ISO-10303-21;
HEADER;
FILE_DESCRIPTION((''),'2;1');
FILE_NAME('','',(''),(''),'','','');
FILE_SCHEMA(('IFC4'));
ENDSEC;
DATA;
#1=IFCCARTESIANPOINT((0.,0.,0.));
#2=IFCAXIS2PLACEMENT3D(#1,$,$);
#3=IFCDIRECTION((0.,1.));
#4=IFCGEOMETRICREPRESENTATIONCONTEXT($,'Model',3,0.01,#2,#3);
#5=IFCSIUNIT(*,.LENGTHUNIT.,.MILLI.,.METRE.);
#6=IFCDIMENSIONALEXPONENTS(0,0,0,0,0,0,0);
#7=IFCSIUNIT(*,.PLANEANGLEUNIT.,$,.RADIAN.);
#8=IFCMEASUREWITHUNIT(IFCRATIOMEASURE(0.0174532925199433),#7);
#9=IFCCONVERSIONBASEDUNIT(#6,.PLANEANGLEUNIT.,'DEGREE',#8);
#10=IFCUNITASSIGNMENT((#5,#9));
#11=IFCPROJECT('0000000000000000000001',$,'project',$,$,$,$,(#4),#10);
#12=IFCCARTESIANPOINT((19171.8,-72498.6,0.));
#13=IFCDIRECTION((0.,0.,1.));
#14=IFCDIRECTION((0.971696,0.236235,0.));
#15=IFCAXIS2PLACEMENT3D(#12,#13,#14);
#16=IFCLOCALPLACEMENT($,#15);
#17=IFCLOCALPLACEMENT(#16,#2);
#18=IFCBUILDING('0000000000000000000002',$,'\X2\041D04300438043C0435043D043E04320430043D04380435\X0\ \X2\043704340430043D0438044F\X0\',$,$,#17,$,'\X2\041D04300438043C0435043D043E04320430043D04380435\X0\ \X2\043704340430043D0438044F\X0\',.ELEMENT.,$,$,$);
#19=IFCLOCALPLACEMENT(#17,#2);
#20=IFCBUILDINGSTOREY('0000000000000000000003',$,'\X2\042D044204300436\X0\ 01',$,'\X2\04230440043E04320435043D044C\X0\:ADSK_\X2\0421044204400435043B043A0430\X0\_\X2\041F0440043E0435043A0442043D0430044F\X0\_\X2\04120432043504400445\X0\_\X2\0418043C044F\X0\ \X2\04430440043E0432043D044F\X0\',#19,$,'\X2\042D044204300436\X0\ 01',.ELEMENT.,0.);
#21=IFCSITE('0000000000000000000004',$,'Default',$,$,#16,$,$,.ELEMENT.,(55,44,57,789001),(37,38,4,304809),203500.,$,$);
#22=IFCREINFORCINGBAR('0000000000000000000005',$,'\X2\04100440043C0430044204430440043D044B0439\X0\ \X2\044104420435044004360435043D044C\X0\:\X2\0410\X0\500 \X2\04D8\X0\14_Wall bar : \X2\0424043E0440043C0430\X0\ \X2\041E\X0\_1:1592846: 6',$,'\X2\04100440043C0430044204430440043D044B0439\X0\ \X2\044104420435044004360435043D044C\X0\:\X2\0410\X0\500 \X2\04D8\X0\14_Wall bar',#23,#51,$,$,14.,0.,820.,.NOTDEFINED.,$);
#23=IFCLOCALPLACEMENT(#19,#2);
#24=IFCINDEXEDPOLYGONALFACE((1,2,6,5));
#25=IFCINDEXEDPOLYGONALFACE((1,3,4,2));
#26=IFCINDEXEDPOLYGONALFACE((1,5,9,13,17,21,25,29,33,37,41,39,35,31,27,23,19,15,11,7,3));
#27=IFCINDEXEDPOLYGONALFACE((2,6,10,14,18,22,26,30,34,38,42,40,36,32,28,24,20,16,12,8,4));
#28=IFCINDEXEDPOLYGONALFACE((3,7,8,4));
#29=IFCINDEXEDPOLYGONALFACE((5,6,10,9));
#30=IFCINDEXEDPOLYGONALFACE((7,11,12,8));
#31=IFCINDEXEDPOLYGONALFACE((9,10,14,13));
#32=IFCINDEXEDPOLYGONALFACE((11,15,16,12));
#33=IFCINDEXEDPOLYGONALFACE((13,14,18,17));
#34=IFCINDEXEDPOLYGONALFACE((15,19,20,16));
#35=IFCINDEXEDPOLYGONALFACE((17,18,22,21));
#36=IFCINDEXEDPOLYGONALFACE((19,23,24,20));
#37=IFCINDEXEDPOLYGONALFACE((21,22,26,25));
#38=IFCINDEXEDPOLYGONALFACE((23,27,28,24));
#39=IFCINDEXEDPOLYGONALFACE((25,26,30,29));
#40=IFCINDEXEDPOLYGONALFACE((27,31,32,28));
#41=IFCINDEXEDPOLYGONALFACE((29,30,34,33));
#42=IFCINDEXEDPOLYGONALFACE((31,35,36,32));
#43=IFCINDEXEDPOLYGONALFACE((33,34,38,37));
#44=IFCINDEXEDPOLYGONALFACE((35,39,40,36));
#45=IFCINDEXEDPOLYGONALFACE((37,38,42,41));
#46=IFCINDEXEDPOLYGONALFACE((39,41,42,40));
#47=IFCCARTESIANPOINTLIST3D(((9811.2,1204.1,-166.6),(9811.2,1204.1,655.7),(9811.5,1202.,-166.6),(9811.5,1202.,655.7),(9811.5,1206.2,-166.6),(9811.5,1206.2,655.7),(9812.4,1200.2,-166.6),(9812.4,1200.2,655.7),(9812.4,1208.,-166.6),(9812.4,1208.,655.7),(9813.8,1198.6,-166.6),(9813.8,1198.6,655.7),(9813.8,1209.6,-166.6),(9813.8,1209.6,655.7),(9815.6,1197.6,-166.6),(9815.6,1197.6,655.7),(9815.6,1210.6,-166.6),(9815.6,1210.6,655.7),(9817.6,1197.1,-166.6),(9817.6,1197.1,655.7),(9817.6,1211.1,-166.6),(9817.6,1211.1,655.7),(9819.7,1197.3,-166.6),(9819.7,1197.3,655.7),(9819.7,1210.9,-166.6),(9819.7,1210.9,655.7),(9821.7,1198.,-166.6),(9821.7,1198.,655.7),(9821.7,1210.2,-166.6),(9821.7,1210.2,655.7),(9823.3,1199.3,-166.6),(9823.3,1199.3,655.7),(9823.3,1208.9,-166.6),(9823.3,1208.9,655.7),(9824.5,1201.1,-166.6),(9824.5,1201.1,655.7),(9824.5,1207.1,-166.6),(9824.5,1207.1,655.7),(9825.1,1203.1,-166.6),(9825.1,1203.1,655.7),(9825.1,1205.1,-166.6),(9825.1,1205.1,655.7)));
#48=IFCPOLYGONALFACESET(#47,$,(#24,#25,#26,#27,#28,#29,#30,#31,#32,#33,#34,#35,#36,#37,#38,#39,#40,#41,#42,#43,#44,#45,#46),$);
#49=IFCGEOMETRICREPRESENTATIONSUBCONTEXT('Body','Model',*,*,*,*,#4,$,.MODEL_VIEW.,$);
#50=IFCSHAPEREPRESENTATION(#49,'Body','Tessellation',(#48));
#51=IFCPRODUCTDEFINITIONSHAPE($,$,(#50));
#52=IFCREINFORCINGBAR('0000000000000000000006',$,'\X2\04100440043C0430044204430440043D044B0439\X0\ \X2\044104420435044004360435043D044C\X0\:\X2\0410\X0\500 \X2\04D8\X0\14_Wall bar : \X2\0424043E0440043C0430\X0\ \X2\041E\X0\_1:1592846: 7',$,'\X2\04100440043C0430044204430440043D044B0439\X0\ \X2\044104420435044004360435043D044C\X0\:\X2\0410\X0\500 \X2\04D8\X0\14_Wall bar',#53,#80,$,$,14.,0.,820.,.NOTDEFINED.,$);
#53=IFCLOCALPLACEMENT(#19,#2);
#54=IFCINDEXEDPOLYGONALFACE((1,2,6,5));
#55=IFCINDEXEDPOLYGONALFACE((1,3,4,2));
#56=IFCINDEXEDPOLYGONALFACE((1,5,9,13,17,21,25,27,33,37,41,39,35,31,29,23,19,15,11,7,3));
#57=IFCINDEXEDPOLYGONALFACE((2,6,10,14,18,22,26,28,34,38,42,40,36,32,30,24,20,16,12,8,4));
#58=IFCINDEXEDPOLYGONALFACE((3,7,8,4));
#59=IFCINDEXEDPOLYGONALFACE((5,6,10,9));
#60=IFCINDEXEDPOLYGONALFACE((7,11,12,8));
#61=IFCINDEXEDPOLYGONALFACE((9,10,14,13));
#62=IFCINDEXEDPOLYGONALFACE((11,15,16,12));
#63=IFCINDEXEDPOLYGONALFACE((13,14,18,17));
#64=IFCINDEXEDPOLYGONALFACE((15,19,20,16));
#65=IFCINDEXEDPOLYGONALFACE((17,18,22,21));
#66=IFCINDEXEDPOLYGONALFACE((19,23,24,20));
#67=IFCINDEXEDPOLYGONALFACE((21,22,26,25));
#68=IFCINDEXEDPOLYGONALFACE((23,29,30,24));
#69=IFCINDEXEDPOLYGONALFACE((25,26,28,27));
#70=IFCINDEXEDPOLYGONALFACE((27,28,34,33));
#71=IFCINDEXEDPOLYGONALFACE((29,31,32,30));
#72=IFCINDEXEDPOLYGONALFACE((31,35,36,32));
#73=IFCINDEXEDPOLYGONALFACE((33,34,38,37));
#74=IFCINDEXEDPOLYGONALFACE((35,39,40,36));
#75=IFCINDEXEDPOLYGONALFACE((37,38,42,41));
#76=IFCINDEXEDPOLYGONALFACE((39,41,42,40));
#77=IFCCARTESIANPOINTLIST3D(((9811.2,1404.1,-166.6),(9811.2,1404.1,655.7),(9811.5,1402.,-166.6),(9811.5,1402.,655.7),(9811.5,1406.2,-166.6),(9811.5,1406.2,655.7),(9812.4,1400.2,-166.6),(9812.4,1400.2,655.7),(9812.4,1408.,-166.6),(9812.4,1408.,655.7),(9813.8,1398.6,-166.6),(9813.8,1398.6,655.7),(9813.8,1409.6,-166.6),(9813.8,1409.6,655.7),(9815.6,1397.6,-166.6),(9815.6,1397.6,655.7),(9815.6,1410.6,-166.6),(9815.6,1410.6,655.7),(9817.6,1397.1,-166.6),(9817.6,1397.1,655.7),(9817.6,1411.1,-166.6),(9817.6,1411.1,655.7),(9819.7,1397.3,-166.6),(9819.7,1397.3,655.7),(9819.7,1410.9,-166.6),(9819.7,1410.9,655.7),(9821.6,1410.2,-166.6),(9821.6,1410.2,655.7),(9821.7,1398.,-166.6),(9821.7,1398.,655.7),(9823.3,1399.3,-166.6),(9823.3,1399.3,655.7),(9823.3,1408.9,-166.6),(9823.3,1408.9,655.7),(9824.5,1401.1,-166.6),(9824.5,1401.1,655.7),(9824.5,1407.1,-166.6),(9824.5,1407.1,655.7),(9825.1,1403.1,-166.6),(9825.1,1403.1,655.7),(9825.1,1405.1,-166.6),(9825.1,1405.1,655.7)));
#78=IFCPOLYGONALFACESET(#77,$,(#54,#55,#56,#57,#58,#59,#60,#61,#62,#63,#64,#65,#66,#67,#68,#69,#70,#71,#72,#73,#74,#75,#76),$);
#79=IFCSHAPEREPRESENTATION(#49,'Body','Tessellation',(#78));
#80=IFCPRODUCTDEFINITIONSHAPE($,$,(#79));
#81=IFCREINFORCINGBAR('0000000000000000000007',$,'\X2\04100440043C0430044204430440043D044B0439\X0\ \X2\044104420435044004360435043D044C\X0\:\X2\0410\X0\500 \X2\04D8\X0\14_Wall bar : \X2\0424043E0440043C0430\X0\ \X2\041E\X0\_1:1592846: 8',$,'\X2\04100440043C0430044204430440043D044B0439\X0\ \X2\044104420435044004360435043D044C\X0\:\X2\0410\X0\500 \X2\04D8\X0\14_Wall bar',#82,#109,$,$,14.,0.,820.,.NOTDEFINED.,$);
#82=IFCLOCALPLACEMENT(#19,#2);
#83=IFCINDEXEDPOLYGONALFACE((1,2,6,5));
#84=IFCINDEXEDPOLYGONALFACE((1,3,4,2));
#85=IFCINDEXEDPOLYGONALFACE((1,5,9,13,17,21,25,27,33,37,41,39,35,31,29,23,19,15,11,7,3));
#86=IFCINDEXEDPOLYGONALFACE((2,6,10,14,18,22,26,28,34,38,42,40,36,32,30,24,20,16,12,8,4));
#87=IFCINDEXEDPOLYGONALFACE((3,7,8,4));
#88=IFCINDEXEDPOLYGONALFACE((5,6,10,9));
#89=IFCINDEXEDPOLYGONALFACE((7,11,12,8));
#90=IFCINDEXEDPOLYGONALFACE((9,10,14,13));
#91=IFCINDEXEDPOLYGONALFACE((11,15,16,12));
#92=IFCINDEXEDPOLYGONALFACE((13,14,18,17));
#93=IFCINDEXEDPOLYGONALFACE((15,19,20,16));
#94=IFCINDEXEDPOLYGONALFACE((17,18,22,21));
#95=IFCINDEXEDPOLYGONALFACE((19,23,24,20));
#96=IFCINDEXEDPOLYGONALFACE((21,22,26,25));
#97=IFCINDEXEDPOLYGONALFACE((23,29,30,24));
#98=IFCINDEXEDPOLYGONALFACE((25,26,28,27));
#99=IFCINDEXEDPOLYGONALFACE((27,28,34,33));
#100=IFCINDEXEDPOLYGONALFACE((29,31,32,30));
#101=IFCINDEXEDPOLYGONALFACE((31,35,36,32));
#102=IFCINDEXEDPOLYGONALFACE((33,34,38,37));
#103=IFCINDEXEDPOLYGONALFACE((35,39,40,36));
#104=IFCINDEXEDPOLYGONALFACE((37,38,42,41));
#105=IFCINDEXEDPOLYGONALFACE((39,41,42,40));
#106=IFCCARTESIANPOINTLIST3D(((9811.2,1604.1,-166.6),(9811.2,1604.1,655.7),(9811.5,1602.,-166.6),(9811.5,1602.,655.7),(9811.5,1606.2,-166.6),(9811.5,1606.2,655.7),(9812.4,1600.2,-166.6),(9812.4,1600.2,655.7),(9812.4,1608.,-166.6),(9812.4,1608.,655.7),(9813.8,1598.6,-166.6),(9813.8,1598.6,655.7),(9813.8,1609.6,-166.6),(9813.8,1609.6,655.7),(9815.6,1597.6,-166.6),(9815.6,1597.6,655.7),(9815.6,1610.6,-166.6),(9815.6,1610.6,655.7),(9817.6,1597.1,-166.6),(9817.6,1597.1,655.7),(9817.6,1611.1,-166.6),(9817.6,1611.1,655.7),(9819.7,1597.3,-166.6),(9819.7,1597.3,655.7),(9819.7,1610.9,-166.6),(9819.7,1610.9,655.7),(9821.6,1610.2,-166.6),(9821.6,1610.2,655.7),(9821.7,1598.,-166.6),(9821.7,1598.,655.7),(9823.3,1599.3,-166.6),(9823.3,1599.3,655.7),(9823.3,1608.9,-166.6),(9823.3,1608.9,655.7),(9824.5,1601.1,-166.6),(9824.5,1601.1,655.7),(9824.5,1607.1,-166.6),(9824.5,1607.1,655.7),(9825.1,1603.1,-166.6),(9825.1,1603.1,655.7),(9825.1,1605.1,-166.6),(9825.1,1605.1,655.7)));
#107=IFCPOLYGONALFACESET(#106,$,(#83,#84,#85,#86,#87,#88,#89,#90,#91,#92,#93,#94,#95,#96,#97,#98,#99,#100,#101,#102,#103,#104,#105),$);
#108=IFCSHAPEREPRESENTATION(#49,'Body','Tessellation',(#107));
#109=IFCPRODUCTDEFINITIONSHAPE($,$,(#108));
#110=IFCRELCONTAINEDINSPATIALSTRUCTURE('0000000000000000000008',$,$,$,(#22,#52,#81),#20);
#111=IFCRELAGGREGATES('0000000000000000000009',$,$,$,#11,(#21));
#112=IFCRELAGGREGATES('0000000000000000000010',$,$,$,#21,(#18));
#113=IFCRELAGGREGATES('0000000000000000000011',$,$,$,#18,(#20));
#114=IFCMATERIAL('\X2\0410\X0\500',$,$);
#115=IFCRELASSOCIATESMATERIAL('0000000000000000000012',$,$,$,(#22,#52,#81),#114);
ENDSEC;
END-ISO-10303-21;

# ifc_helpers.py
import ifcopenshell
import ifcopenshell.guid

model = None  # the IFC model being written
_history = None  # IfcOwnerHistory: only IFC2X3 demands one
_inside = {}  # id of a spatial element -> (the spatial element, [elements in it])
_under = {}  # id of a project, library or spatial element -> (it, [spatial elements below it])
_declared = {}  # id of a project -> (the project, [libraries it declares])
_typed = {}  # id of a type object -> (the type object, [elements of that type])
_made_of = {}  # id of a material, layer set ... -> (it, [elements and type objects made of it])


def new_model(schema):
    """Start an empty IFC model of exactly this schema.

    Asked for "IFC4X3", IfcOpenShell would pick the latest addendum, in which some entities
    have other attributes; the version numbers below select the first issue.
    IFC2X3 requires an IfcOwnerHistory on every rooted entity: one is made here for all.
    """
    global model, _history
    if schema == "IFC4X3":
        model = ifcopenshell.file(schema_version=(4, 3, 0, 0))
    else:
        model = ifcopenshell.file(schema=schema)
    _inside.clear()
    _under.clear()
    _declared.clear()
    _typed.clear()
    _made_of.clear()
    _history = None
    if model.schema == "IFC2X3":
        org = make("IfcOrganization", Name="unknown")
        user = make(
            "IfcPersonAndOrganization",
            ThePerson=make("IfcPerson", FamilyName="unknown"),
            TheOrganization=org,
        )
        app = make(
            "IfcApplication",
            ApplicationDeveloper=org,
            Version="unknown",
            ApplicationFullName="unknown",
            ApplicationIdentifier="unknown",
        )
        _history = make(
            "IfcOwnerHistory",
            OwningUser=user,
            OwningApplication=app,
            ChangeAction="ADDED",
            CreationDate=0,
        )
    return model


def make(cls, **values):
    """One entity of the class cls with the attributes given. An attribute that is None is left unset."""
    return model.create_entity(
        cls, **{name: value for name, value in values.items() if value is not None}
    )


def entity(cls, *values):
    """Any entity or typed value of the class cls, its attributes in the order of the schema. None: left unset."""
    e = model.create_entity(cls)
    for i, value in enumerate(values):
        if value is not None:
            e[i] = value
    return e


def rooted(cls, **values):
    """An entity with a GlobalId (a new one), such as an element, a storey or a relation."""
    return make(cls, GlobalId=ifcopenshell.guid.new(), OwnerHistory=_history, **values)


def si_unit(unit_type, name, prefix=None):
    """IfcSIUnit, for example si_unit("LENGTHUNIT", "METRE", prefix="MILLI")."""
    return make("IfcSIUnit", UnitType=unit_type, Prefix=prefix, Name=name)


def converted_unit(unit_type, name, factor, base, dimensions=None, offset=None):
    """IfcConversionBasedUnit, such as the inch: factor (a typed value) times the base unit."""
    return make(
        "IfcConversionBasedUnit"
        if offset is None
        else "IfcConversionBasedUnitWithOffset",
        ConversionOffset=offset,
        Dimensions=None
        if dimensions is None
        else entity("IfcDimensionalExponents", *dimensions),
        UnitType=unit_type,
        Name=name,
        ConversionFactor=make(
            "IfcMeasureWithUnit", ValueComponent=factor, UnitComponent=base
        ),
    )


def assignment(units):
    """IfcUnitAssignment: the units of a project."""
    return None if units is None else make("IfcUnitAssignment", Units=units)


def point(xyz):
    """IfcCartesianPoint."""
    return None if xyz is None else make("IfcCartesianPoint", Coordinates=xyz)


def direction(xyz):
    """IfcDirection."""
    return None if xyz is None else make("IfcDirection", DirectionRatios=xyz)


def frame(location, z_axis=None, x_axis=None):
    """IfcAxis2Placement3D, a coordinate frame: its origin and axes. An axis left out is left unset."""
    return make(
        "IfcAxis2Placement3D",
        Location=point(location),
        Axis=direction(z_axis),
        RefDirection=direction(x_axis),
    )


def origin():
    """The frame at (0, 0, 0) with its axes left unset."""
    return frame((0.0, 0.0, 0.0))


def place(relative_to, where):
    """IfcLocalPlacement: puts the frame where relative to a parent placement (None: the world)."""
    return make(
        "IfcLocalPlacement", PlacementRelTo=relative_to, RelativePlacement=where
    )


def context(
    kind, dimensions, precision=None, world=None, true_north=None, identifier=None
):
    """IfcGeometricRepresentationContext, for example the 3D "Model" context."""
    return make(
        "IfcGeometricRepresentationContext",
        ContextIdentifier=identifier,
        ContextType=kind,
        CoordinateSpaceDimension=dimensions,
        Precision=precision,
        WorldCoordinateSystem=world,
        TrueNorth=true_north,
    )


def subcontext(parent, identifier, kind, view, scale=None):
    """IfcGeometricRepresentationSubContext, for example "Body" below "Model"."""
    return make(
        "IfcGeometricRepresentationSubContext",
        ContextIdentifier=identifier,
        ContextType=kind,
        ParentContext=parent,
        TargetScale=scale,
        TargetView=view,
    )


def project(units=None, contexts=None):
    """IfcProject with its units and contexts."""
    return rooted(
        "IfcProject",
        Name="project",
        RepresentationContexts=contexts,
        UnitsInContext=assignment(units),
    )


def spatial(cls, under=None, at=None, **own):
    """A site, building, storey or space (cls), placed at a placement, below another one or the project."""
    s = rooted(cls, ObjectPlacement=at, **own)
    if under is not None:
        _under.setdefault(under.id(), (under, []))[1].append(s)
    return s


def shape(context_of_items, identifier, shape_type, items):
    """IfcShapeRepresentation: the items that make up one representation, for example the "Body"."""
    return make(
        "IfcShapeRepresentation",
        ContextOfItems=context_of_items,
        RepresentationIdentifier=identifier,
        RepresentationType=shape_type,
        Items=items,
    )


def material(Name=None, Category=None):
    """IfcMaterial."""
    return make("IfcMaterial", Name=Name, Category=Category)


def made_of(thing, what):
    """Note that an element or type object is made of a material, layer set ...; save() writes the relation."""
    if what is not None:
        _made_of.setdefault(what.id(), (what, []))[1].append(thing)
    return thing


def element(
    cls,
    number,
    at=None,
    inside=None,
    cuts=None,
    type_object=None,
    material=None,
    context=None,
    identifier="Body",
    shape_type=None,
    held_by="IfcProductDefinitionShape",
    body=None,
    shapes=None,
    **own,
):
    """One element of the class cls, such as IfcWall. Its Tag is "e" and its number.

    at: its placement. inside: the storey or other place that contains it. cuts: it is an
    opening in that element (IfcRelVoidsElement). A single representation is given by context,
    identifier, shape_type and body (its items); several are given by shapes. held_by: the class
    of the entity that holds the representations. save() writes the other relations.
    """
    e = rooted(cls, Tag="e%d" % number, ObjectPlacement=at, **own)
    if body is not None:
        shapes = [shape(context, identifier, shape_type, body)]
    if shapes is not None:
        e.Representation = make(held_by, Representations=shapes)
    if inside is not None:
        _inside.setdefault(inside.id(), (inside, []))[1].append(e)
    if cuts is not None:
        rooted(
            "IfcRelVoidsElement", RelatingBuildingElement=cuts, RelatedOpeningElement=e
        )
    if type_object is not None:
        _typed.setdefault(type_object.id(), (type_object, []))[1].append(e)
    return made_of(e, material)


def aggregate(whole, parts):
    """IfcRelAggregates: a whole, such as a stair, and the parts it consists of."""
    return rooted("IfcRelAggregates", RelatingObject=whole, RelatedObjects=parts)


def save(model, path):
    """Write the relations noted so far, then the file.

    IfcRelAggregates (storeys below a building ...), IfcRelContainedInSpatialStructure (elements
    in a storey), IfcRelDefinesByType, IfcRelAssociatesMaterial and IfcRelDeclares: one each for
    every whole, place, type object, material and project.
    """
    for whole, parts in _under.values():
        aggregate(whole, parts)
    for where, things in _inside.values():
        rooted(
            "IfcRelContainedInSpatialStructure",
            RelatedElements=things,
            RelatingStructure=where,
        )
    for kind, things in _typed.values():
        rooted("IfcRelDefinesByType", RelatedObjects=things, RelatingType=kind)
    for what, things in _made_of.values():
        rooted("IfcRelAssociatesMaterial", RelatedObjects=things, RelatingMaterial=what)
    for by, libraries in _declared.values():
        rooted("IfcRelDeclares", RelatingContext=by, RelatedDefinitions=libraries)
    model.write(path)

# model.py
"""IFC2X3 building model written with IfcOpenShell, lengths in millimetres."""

from ifc_helpers import new_model, entity, si_unit, converted_unit, direction, frame, origin, place, context, subcontext, project, spatial, material, element, save


model = new_model("IFC2X3")

# Units and contexts
model_context = context("Model", 3, precision=0.01, world=origin(), true_north=direction((0.0, 1.0)))
body_context = subcontext(model_context, "Body", "Model", "MODEL_VIEW")
ifc_project = project(units=[si_unit("LENGTHUNIT", "METRE", prefix="MILLI"), converted_unit("PLANEANGLEUNIT", "DEGREE", entity("IfcRatioMeasure", 0.0174532925199433), si_unit("PLANEANGLEUNIT", "RADIAN"), dimensions=[0, 0, 0, 0, 0, 0, 0])], contexts=[model_context])

# Site, building, storey
site_placement = place(None, frame((19171.8, -72498.6, 0.0), z_axis=(0.0, 0.0, 1.0), x_axis=(0.971696, 0.236235, 0.0)))
site = spatial("IfcSite", under=ifc_project, at=site_placement, Name="Default", CompositionType="ELEMENT", RefLatitude=(55, 44, 57, 789001), RefLongitude=(37, 38, 4, 304809), RefElevation=203500.0)
building_placement = place(site_placement, origin())
building = spatial("IfcBuilding", under=site, at=building_placement, Name="Наименование здания", LongName="Наименование здания", CompositionType="ELEMENT")
storey_placement = place(building_placement, origin())
storey = spatial("IfcBuildingStorey", under=building, at=storey_placement, Name="Этаж 01", ObjectType="Уровень:ADSK_Стрелка_Проектная_Вверх_Имя уровня", LongName="Этаж 01", CompositionType="ELEMENT", Elevation=0.0)

# Reinforcing bars
ifc_material = material(Name="А500")
placement = place(storey_placement, origin())
element("IfcReinforcingBar", 1, at=placement, inside=storey, material=ifc_material, Name="Арматурный стержень:А500 Ә14_Wall bar : Форма О_1:1592846: 6", ObjectType="Арматурный стержень:А500 Ә14_Wall bar", BarLength=820.0, BarRole="NOTDEFINED", CrossSectionArea=0.0, NominalDiameter=14.0, context=body_context, shape_type="AdvancedSweptSolid", body=[
    entity("IfcSweptDiskSolid", entity("IfcCompositeCurve", [entity("IfcCompositeCurveSegment", "CONTINUOUS", True, entity("IfcPolyline", [entity("IfcCartesianPoint", [9818.1, 1204.1, 655.7]), entity("IfcCartesianPoint", [9818.1, 1204.1, -166.6])]))], False), 7.0, None, 0.0, 1.0),
])
element("IfcReinforcingBar", 2, at=placement, inside=storey, material=ifc_material, Name="Арматурный стержень:А500 Ә14_Wall bar : Форма О_1:1592846: 7", ObjectType="Арматурный стержень:А500 Ә14_Wall bar", BarLength=820.0, BarRole="NOTDEFINED", CrossSectionArea=0.0, NominalDiameter=14.0, context=body_context, shape_type="AdvancedSweptSolid", body=[
    entity("IfcSweptDiskSolid", entity("IfcCompositeCurve", [entity("IfcCompositeCurveSegment", "CONTINUOUS", True, entity("IfcPolyline", [entity("IfcCartesianPoint", [9818.1, 1404.1, 655.7]), entity("IfcCartesianPoint", [9818.1, 1404.1, -166.6])]))], False), 7.0, None, 0.0, 1.0),
])
element("IfcReinforcingBar", 3, at=placement, inside=storey, material=ifc_material, Name="Арматурный стержень:А500 Ә14_Wall bar : Форма О_1:1592846: 8", ObjectType="Арматурный стержень:А500 Ә14_Wall bar", BarLength=820.0, BarRole="NOTDEFINED", CrossSectionArea=0.0, NominalDiameter=14.0, context=body_context, shape_type="AdvancedSweptSolid", body=[
    entity("IfcSweptDiskSolid", entity("IfcCompositeCurve", [entity("IfcCompositeCurveSegment", "CONTINUOUS", True, entity("IfcPolyline", [entity("IfcCartesianPoint", [9818.1, 1604.1, 655.7]), entity("IfcCartesianPoint", [9818.1, 1604.1, -166.6])]))], False), 7.0, None, 0.0, 1.0),
])

save(model, "model.ifc")
